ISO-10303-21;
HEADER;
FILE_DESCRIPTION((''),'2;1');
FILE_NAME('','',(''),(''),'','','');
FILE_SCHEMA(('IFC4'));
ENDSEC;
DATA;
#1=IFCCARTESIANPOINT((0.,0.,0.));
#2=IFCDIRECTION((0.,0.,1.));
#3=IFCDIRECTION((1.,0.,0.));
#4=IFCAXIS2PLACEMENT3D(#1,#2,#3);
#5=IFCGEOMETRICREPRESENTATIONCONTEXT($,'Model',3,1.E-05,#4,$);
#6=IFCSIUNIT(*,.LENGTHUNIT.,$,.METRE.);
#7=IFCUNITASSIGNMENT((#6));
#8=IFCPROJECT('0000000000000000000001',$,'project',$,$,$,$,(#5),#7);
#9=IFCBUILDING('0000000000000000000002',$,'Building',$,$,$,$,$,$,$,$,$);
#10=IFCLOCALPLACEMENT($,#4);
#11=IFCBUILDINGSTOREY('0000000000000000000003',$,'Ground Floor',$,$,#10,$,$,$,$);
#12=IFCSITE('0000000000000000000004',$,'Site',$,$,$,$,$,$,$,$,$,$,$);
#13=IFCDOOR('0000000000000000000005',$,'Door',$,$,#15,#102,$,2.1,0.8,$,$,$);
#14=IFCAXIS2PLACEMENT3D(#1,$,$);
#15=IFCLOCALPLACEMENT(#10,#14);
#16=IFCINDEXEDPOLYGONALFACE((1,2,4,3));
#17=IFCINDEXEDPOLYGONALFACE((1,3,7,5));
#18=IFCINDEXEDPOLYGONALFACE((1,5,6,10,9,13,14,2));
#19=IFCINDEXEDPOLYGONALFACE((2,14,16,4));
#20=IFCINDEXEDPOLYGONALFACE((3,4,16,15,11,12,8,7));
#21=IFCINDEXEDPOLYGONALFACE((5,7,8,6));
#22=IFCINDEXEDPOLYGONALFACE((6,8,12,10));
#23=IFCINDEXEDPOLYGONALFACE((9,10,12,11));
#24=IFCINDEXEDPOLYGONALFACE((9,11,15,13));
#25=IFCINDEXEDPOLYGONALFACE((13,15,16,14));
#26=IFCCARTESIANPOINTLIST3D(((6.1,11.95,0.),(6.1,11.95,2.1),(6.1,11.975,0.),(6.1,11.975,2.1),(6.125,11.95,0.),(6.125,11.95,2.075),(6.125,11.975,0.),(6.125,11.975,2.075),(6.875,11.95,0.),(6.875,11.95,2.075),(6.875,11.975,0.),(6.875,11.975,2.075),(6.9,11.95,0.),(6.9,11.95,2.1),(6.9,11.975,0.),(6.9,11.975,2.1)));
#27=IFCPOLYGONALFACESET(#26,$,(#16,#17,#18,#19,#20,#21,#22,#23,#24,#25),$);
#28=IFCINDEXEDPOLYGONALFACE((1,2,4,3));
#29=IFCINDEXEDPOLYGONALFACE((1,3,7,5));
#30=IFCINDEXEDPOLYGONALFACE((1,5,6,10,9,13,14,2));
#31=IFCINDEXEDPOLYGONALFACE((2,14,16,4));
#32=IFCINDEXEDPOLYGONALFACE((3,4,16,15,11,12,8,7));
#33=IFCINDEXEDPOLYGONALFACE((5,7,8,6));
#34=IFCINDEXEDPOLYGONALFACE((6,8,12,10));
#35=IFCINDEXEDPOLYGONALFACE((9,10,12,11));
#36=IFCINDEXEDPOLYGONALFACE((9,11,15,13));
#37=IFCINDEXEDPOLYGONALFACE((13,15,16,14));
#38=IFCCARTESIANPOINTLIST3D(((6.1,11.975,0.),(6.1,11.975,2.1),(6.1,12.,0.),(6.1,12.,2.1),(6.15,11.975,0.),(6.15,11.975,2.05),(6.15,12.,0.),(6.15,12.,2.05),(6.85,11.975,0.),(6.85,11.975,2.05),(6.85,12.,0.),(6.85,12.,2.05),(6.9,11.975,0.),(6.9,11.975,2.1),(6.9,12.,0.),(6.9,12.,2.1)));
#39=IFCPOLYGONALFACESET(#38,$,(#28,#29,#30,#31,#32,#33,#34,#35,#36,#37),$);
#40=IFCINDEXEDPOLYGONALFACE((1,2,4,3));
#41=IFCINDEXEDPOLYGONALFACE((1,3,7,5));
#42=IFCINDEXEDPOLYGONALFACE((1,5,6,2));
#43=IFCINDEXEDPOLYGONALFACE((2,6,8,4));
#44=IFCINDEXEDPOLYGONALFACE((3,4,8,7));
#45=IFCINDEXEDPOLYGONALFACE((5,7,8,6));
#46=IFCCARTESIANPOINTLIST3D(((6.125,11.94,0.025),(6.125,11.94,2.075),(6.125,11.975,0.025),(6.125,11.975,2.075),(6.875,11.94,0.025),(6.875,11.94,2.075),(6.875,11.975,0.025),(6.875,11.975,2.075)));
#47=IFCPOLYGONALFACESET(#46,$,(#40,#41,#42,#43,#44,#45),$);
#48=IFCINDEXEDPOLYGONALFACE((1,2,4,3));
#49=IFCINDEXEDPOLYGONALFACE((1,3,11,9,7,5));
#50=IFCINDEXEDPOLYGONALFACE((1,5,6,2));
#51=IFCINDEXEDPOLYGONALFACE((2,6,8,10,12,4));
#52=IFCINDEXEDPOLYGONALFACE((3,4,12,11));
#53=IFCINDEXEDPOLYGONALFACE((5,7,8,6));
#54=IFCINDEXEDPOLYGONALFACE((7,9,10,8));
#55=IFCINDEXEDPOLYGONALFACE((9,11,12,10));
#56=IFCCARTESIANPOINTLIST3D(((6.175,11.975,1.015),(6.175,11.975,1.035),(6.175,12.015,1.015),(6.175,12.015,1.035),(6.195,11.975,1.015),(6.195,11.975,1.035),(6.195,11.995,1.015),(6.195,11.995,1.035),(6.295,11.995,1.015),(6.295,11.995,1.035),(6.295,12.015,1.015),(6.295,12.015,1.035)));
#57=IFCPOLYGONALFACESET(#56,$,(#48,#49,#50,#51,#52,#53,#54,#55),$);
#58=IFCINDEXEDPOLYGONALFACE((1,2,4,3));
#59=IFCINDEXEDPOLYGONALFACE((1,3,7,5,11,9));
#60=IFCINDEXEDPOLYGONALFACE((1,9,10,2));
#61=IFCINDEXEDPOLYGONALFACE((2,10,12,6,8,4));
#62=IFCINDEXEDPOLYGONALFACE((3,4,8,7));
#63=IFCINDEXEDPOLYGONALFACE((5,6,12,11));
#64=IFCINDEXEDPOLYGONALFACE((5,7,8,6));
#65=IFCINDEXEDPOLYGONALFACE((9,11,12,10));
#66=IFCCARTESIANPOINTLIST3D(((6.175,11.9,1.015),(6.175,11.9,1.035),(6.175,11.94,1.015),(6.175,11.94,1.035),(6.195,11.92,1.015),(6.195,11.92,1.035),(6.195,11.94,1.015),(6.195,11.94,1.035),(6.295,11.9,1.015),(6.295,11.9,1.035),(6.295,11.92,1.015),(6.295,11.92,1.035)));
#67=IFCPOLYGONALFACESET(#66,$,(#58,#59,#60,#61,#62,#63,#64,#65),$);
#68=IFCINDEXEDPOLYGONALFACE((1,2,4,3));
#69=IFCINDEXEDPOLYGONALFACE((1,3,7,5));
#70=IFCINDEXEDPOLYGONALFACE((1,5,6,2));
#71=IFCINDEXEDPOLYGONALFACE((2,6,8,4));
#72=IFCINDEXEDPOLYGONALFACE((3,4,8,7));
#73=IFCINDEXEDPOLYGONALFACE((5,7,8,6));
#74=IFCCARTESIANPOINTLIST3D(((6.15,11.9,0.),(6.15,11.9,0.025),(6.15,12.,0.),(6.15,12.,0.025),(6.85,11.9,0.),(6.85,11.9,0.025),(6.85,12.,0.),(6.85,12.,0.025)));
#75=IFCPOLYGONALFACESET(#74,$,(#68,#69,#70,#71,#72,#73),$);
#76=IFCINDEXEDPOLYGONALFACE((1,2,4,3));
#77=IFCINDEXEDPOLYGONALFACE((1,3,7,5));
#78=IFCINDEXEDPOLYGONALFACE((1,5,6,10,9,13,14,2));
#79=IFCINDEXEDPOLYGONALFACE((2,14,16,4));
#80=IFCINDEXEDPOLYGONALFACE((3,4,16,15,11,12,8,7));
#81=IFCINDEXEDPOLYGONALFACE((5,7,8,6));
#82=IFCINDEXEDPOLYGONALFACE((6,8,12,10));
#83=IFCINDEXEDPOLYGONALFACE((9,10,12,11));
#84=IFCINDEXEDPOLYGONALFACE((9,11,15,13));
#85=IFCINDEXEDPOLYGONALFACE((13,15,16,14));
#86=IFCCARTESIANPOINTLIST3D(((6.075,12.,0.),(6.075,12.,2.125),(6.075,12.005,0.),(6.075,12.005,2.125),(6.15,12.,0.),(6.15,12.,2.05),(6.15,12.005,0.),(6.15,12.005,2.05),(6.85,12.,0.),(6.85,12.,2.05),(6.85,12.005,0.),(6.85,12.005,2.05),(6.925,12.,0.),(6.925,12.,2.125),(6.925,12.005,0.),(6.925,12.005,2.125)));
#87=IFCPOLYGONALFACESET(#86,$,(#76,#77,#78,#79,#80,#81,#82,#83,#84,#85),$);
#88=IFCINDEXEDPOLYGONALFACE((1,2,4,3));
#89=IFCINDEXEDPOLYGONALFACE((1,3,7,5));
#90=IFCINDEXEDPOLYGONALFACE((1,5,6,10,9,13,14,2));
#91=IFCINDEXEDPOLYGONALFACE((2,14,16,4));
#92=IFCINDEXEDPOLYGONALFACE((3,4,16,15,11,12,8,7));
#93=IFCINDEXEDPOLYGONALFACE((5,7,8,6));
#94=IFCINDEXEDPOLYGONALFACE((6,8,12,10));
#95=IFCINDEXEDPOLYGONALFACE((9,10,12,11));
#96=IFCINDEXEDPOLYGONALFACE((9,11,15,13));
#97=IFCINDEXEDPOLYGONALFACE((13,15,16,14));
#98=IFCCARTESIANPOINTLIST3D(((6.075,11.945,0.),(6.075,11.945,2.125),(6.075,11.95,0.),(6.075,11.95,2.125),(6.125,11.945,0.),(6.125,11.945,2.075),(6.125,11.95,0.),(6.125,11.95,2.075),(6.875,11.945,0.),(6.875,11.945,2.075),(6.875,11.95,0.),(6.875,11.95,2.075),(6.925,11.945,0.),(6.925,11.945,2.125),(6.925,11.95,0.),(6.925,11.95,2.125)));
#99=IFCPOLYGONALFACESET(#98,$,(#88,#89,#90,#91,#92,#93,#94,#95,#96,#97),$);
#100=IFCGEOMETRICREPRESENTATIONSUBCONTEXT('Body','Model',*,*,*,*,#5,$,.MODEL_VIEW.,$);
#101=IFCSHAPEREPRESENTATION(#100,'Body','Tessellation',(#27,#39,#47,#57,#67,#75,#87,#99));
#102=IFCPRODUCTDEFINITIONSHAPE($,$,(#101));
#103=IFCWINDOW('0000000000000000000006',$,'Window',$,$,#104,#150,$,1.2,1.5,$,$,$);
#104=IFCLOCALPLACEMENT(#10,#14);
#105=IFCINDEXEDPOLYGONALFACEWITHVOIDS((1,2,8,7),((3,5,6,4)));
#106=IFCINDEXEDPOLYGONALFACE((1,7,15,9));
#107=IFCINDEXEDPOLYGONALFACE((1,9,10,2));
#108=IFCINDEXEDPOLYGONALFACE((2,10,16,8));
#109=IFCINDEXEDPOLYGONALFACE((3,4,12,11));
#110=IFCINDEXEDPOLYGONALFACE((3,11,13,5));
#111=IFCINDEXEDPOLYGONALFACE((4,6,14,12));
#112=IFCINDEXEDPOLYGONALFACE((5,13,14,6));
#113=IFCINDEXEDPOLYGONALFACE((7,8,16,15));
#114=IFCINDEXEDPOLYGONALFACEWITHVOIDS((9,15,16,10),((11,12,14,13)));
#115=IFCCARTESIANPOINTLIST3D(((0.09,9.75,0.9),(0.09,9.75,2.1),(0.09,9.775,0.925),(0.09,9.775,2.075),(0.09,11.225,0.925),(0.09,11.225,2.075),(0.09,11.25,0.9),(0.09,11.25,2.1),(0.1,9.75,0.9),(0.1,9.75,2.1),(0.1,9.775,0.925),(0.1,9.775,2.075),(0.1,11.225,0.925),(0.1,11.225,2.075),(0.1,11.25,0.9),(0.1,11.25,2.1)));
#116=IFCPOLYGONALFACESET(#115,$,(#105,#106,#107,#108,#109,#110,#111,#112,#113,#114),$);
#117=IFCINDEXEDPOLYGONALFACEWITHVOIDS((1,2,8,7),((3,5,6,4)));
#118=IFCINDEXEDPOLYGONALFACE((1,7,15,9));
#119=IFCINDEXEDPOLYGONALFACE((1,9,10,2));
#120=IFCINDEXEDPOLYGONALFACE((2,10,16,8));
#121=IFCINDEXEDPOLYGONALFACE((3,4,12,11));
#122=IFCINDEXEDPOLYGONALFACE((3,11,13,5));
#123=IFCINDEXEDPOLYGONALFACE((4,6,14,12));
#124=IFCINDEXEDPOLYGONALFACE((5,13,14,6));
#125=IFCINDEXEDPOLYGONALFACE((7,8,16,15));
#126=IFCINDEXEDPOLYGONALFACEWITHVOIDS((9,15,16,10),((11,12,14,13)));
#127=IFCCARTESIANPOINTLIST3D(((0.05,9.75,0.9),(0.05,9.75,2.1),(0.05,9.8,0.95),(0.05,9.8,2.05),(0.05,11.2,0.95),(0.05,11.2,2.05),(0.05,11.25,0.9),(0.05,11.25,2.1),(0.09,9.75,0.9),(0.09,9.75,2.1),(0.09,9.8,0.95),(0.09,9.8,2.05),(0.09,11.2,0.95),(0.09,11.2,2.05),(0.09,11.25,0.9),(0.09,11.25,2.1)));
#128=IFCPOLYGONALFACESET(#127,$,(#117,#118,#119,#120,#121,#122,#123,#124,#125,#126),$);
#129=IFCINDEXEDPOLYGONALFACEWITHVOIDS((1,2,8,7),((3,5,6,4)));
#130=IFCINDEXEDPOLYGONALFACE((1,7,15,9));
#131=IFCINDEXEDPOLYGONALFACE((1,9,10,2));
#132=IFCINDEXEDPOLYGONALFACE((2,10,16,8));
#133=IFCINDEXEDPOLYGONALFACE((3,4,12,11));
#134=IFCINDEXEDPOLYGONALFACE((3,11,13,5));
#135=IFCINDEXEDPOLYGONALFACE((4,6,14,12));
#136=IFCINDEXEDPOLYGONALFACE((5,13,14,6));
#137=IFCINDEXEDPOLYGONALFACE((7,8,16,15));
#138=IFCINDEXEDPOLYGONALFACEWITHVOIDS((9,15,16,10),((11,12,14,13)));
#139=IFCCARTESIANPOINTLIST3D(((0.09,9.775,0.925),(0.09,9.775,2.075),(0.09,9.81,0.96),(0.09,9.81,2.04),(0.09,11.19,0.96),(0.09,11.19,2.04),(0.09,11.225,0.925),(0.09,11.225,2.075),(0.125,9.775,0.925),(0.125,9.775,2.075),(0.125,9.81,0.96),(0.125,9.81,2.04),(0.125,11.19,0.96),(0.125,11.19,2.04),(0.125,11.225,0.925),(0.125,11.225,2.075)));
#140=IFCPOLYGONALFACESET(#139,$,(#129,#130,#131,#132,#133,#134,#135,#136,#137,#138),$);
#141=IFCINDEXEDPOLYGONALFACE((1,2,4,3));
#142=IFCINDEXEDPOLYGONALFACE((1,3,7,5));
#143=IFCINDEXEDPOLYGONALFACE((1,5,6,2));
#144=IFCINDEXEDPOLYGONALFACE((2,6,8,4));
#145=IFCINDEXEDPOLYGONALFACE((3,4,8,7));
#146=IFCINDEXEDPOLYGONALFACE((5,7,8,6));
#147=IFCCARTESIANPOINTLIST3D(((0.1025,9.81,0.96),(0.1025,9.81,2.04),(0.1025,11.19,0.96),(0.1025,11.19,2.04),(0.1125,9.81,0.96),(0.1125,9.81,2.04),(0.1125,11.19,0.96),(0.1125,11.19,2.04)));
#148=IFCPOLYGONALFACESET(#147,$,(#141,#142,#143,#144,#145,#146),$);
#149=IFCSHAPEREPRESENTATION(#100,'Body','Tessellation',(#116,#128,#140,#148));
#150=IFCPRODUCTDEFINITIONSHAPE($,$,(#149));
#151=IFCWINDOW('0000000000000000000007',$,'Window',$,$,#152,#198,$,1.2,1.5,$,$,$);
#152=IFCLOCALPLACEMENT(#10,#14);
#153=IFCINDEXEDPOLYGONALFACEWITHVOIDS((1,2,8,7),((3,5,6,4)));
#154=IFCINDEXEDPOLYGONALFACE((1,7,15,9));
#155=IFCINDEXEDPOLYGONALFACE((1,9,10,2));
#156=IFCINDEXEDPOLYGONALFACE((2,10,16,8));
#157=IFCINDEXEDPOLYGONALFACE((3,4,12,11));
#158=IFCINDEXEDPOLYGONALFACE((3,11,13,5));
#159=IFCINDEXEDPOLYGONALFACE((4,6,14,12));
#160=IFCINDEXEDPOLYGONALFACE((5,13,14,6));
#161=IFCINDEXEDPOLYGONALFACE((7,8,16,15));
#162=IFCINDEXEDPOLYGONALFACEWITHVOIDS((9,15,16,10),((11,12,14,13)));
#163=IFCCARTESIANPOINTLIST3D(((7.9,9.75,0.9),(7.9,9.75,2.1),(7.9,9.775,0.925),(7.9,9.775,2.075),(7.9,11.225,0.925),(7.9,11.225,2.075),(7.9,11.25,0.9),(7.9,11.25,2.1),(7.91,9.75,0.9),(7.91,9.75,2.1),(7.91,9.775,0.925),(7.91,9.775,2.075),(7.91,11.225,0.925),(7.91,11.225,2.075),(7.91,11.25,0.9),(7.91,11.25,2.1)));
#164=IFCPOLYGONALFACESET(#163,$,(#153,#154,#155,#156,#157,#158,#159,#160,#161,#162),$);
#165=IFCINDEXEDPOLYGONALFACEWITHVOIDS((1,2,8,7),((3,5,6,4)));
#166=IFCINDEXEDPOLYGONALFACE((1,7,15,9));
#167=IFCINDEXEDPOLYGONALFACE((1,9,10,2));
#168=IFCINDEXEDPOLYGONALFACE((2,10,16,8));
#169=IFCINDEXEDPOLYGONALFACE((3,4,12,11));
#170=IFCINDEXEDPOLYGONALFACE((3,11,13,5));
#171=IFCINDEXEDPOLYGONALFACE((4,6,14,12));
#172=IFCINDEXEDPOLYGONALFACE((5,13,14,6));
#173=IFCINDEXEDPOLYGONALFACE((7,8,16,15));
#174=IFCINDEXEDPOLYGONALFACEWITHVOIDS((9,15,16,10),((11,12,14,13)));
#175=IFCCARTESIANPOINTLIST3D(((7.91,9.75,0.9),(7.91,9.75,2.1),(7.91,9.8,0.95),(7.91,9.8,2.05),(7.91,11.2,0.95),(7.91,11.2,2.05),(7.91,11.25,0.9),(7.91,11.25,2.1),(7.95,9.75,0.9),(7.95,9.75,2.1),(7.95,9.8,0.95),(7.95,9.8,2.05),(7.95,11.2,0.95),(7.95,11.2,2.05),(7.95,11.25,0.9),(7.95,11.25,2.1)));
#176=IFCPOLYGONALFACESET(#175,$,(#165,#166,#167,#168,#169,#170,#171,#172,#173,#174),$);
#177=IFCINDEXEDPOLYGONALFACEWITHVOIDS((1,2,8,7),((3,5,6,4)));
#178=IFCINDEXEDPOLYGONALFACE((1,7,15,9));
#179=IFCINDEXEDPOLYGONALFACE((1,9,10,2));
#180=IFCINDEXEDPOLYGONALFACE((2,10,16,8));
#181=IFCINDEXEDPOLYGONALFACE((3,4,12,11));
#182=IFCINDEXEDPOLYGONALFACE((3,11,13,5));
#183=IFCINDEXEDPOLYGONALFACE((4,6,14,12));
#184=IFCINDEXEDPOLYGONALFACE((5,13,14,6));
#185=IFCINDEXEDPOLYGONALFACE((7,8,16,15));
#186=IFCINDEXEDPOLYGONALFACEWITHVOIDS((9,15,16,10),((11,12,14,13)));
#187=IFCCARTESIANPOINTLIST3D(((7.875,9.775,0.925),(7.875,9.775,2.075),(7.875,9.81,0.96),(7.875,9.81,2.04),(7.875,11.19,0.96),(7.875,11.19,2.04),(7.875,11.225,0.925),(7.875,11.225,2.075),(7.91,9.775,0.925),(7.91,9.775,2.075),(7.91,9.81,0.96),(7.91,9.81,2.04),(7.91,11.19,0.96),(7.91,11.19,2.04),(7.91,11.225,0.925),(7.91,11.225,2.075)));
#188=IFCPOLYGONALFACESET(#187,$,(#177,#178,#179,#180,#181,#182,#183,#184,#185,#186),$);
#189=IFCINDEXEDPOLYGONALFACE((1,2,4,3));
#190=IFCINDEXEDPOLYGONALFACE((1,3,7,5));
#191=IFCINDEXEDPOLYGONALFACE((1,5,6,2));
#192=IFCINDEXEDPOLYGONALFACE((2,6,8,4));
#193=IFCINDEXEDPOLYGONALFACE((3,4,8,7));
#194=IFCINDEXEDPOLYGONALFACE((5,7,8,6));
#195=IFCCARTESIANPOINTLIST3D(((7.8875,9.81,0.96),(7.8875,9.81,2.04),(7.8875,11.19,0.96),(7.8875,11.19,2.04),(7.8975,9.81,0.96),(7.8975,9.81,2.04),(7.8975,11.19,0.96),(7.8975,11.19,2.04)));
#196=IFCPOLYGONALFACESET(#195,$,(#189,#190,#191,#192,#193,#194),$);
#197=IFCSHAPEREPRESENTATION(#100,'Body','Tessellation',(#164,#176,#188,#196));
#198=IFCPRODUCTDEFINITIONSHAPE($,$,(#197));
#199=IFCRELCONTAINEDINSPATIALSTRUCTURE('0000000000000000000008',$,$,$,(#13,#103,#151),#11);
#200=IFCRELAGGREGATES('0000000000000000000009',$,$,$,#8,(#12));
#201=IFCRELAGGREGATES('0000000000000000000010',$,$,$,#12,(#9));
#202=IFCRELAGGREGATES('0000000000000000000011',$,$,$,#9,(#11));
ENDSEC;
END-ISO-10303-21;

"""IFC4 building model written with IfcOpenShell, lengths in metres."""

from ifc_helpers import new_model, si_unit, frame, origin_with_axes, place, context, subcontext, project, spatial, line, indexed_curve, outline, extrude, element, save


model = new_model("IFC4")

# Units and contexts
model_context = context("Model", 3, precision=1e-05, world=origin_with_axes())
body_context = subcontext(model_context, "Body", "Model", "MODEL_VIEW")
ifc_project = project(units=[si_unit("LENGTHUNIT", "METRE")], contexts=[model_context])

# Site, building, storey
site = spatial("IfcSite", under=ifc_project, Name="Site")
building = spatial("IfcBuilding", under=site, Name="Building")
storey_placement = place(None, origin_with_axes())
storey = spatial("IfcBuildingStorey", under=building, at=storey_placement, Name="Ground Floor")

# Door
door_1_placement = place(storey_placement, frame((6.9, 12.0, 0.0), z_axis=(0.0, 0.0, 1.0), x_axis=(-1.0, 0.0, 0.0)))
element("IfcDoor", 1, at=door_1_placement, inside=storey, Name="Door", OverallHeight=2.1, OverallWidth=0.8, context=body_context, shape_type="SweptSolid", body=[
    extrude(outline(indexed_curve([(0.0, 0.0), (0.0, 2.1), (0.8, 2.1), (0.8, 0.0), (0.775, 0.0), (0.775, 2.075), (0.025, 2.075), (0.025, 0.0)], segments=[line(1, 2, 3, 4, 5, 6, 7, 8, 1)])), frame((0.0, 0.025, 0.0), z_axis=(0.0, -1.0, 0.0), x_axis=(1.0, 0.0, 0.0)), (0.0, 0.0, -1.0), 0.025),
    extrude(outline(indexed_curve([(0.0, 0.0), (0.0, 2.1), (0.8, 2.1), (0.8, 0.0), (0.75, 0.0), (0.75, 2.05), (0.05, 2.05), (0.05, 0.0)], segments=[line(1, 2, 3, 4, 5, 6, 7, 8, 1)])), frame((0.0, 0.0, 0.0), z_axis=(0.0, -1.0, 0.0), x_axis=(1.0, 0.0, 0.0)), (0.0, 0.0, -1.0), 0.025),
    extrude(outline(indexed_curve([(0.0, 0.0), (0.75, 0.0), (0.75, 0.035), (0.0, 0.035)], segments=[line(1, 2, 3, 4, 1)])), frame((0.025, 0.025, 0.025), z_axis=(0.0, 0.0, 1.0), x_axis=(1.0, 0.0, 0.0)), (0.0, 0.0, 1.0), 2.05),
    extrude(outline(indexed_curve([(0.0, 0.0), (0.0, -0.04), (-0.12, -0.04), (-0.12, -0.02), (-0.02, -0.02), (-0.02, 0.0)], segments=[line(1, 2, 3, 4, 5, 6, 1)])), frame((0.725, 0.025, 1.015), z_axis=(0.0, 0.0, 1.0), x_axis=(1.0, 0.0, 0.0)), (0.0, 0.0, 1.0), 0.02),
    extrude(outline(indexed_curve([(0.0, 0.0), (0.0, 0.04), (-0.12, 0.04), (-0.12, 0.02), (-0.02, 0.02), (-0.02, 0.0)], segments=[line(1, 2, 3, 4, 5, 6, 1)])), frame((0.725, 0.06, 1.015), z_axis=(0.0, 0.0, 1.0), x_axis=(1.0, 0.0, 0.0)), (0.0, 0.0, 1.0), 0.02),
    extrude(outline(indexed_curve([(0.0, 0.0), (0.7, 0.0), (0.7, 0.1), (0.0, 0.1)], segments=[line(1, 2, 3, 4, 1)])), frame((0.05, 0.0, 0.0), z_axis=(0.0, 0.0, 1.0), x_axis=(1.0, 0.0, 0.0)), (0.0, 0.0, 1.0), 0.025),
    extrude(outline(indexed_curve([(0.0, 0.0), (0.0, 2.125), (0.85, 2.125), (0.85, 0.0), (0.775, 0.0), (0.775, 2.05), (0.075, 2.05), (0.075, 0.0)], segments=[line(1, 2, 3, 4, 5, 6, 7, 8, 1)])), frame((-0.025, -0.005, 0.0), z_axis=(0.0, -1.0, 0.0), x_axis=(1.0, 0.0, 0.0)), (0.0, 0.0, -1.0), 0.005),
    extrude(outline(indexed_curve([(0.0, 0.0), (0.0, 2.125), (0.85, 2.125), (0.85, 0.0), (0.8, 0.0), (0.8, 2.075), (0.05, 2.075), (0.05, 0.0)], segments=[line(1, 2, 3, 4, 5, 6, 7, 8, 1)])), frame((-0.025, 0.05, 0.0), z_axis=(0.0, -1.0, 0.0), x_axis=(1.0, 0.0, 0.0)), (0.0, 0.0, -1.0), 0.005),
])

# Windows
for number, where, z_axis, x_axis, name in (
    (2, (0.0, 11.25, 0.9), (0.0, 0.0, 1.0), (0.0, -1.0, 0.0), "Window"),
    (3, (8.0, 9.75, 0.9), (0.0, 0.0, 1.0), (0.0, 1.0, 0.0), "Window"),
):
    element("IfcWindow", number, at=place(storey_placement, frame(where, z_axis=z_axis, x_axis=x_axis)), inside=storey, Name=name, OverallHeight=1.2, OverallWidth=1.5, context=body_context, shape_type="SweptSolid", body=[
        extrude(outline(indexed_curve([(0.0, 0.0), (1.5, 0.0), (1.5, 1.2), (0.0, 1.2)], segments=[line(1, 2, 3, 4, 1)]), holes=[indexed_curve([(0.025, 0.025), (1.475, 0.025), (1.475, 1.175), (0.025, 1.175)], segments=[line(1, 2, 3, 4, 1)])]), frame((0.0, 0.09, 0.0), z_axis=(0.0, -1.0, 0.0), x_axis=(1.0, 0.0, 0.0)), (0.0, 0.0, -1.0), 0.01),
        extrude(outline(indexed_curve([(0.0, 0.0), (1.5, 0.0), (1.5, 1.2), (0.0, 1.2)], segments=[line(1, 2, 3, 4, 1)]), holes=[indexed_curve([(0.05, 0.05), (1.45, 0.05), (1.45, 1.15), (0.05, 1.15)], segments=[line(1, 2, 3, 4, 1)])]), frame((0.0, 0.05, 0.0), z_axis=(0.0, -1.0, 0.0), x_axis=(1.0, 0.0, 0.0)), (0.0, 0.0, -1.0), 0.04),
        extrude(outline(indexed_curve([(0.0, 0.0), (1.45, 0.0), (1.45, 1.15), (0.0, 1.15)], segments=[line(1, 2, 3, 4, 1)]), holes=[indexed_curve([(0.035, 0.035), (1.415, 0.035), (1.415, 1.115), (0.035, 1.115)], segments=[line(1, 2, 3, 4, 1)])]), frame((0.025, 0.09, 0.025), z_axis=(0.0, -1.0, 0.0), x_axis=(1.0, 0.0, 0.0)), (0.0, 0.0, -1.0), 0.035),
        extrude(outline(indexed_curve([(0.035, 0.035), (1.415, 0.035), (1.415, 1.115), (0.035, 1.115)], segments=[line(1, 2, 3, 4, 1)])), frame((0.025, 0.1025, 0.025), z_axis=(0.0, -1.0, 0.0), x_axis=(1.0, 0.0, 0.0)), (0.0, 0.0, -1.0), 0.01),
    ])

save(model, "model.ifc")
